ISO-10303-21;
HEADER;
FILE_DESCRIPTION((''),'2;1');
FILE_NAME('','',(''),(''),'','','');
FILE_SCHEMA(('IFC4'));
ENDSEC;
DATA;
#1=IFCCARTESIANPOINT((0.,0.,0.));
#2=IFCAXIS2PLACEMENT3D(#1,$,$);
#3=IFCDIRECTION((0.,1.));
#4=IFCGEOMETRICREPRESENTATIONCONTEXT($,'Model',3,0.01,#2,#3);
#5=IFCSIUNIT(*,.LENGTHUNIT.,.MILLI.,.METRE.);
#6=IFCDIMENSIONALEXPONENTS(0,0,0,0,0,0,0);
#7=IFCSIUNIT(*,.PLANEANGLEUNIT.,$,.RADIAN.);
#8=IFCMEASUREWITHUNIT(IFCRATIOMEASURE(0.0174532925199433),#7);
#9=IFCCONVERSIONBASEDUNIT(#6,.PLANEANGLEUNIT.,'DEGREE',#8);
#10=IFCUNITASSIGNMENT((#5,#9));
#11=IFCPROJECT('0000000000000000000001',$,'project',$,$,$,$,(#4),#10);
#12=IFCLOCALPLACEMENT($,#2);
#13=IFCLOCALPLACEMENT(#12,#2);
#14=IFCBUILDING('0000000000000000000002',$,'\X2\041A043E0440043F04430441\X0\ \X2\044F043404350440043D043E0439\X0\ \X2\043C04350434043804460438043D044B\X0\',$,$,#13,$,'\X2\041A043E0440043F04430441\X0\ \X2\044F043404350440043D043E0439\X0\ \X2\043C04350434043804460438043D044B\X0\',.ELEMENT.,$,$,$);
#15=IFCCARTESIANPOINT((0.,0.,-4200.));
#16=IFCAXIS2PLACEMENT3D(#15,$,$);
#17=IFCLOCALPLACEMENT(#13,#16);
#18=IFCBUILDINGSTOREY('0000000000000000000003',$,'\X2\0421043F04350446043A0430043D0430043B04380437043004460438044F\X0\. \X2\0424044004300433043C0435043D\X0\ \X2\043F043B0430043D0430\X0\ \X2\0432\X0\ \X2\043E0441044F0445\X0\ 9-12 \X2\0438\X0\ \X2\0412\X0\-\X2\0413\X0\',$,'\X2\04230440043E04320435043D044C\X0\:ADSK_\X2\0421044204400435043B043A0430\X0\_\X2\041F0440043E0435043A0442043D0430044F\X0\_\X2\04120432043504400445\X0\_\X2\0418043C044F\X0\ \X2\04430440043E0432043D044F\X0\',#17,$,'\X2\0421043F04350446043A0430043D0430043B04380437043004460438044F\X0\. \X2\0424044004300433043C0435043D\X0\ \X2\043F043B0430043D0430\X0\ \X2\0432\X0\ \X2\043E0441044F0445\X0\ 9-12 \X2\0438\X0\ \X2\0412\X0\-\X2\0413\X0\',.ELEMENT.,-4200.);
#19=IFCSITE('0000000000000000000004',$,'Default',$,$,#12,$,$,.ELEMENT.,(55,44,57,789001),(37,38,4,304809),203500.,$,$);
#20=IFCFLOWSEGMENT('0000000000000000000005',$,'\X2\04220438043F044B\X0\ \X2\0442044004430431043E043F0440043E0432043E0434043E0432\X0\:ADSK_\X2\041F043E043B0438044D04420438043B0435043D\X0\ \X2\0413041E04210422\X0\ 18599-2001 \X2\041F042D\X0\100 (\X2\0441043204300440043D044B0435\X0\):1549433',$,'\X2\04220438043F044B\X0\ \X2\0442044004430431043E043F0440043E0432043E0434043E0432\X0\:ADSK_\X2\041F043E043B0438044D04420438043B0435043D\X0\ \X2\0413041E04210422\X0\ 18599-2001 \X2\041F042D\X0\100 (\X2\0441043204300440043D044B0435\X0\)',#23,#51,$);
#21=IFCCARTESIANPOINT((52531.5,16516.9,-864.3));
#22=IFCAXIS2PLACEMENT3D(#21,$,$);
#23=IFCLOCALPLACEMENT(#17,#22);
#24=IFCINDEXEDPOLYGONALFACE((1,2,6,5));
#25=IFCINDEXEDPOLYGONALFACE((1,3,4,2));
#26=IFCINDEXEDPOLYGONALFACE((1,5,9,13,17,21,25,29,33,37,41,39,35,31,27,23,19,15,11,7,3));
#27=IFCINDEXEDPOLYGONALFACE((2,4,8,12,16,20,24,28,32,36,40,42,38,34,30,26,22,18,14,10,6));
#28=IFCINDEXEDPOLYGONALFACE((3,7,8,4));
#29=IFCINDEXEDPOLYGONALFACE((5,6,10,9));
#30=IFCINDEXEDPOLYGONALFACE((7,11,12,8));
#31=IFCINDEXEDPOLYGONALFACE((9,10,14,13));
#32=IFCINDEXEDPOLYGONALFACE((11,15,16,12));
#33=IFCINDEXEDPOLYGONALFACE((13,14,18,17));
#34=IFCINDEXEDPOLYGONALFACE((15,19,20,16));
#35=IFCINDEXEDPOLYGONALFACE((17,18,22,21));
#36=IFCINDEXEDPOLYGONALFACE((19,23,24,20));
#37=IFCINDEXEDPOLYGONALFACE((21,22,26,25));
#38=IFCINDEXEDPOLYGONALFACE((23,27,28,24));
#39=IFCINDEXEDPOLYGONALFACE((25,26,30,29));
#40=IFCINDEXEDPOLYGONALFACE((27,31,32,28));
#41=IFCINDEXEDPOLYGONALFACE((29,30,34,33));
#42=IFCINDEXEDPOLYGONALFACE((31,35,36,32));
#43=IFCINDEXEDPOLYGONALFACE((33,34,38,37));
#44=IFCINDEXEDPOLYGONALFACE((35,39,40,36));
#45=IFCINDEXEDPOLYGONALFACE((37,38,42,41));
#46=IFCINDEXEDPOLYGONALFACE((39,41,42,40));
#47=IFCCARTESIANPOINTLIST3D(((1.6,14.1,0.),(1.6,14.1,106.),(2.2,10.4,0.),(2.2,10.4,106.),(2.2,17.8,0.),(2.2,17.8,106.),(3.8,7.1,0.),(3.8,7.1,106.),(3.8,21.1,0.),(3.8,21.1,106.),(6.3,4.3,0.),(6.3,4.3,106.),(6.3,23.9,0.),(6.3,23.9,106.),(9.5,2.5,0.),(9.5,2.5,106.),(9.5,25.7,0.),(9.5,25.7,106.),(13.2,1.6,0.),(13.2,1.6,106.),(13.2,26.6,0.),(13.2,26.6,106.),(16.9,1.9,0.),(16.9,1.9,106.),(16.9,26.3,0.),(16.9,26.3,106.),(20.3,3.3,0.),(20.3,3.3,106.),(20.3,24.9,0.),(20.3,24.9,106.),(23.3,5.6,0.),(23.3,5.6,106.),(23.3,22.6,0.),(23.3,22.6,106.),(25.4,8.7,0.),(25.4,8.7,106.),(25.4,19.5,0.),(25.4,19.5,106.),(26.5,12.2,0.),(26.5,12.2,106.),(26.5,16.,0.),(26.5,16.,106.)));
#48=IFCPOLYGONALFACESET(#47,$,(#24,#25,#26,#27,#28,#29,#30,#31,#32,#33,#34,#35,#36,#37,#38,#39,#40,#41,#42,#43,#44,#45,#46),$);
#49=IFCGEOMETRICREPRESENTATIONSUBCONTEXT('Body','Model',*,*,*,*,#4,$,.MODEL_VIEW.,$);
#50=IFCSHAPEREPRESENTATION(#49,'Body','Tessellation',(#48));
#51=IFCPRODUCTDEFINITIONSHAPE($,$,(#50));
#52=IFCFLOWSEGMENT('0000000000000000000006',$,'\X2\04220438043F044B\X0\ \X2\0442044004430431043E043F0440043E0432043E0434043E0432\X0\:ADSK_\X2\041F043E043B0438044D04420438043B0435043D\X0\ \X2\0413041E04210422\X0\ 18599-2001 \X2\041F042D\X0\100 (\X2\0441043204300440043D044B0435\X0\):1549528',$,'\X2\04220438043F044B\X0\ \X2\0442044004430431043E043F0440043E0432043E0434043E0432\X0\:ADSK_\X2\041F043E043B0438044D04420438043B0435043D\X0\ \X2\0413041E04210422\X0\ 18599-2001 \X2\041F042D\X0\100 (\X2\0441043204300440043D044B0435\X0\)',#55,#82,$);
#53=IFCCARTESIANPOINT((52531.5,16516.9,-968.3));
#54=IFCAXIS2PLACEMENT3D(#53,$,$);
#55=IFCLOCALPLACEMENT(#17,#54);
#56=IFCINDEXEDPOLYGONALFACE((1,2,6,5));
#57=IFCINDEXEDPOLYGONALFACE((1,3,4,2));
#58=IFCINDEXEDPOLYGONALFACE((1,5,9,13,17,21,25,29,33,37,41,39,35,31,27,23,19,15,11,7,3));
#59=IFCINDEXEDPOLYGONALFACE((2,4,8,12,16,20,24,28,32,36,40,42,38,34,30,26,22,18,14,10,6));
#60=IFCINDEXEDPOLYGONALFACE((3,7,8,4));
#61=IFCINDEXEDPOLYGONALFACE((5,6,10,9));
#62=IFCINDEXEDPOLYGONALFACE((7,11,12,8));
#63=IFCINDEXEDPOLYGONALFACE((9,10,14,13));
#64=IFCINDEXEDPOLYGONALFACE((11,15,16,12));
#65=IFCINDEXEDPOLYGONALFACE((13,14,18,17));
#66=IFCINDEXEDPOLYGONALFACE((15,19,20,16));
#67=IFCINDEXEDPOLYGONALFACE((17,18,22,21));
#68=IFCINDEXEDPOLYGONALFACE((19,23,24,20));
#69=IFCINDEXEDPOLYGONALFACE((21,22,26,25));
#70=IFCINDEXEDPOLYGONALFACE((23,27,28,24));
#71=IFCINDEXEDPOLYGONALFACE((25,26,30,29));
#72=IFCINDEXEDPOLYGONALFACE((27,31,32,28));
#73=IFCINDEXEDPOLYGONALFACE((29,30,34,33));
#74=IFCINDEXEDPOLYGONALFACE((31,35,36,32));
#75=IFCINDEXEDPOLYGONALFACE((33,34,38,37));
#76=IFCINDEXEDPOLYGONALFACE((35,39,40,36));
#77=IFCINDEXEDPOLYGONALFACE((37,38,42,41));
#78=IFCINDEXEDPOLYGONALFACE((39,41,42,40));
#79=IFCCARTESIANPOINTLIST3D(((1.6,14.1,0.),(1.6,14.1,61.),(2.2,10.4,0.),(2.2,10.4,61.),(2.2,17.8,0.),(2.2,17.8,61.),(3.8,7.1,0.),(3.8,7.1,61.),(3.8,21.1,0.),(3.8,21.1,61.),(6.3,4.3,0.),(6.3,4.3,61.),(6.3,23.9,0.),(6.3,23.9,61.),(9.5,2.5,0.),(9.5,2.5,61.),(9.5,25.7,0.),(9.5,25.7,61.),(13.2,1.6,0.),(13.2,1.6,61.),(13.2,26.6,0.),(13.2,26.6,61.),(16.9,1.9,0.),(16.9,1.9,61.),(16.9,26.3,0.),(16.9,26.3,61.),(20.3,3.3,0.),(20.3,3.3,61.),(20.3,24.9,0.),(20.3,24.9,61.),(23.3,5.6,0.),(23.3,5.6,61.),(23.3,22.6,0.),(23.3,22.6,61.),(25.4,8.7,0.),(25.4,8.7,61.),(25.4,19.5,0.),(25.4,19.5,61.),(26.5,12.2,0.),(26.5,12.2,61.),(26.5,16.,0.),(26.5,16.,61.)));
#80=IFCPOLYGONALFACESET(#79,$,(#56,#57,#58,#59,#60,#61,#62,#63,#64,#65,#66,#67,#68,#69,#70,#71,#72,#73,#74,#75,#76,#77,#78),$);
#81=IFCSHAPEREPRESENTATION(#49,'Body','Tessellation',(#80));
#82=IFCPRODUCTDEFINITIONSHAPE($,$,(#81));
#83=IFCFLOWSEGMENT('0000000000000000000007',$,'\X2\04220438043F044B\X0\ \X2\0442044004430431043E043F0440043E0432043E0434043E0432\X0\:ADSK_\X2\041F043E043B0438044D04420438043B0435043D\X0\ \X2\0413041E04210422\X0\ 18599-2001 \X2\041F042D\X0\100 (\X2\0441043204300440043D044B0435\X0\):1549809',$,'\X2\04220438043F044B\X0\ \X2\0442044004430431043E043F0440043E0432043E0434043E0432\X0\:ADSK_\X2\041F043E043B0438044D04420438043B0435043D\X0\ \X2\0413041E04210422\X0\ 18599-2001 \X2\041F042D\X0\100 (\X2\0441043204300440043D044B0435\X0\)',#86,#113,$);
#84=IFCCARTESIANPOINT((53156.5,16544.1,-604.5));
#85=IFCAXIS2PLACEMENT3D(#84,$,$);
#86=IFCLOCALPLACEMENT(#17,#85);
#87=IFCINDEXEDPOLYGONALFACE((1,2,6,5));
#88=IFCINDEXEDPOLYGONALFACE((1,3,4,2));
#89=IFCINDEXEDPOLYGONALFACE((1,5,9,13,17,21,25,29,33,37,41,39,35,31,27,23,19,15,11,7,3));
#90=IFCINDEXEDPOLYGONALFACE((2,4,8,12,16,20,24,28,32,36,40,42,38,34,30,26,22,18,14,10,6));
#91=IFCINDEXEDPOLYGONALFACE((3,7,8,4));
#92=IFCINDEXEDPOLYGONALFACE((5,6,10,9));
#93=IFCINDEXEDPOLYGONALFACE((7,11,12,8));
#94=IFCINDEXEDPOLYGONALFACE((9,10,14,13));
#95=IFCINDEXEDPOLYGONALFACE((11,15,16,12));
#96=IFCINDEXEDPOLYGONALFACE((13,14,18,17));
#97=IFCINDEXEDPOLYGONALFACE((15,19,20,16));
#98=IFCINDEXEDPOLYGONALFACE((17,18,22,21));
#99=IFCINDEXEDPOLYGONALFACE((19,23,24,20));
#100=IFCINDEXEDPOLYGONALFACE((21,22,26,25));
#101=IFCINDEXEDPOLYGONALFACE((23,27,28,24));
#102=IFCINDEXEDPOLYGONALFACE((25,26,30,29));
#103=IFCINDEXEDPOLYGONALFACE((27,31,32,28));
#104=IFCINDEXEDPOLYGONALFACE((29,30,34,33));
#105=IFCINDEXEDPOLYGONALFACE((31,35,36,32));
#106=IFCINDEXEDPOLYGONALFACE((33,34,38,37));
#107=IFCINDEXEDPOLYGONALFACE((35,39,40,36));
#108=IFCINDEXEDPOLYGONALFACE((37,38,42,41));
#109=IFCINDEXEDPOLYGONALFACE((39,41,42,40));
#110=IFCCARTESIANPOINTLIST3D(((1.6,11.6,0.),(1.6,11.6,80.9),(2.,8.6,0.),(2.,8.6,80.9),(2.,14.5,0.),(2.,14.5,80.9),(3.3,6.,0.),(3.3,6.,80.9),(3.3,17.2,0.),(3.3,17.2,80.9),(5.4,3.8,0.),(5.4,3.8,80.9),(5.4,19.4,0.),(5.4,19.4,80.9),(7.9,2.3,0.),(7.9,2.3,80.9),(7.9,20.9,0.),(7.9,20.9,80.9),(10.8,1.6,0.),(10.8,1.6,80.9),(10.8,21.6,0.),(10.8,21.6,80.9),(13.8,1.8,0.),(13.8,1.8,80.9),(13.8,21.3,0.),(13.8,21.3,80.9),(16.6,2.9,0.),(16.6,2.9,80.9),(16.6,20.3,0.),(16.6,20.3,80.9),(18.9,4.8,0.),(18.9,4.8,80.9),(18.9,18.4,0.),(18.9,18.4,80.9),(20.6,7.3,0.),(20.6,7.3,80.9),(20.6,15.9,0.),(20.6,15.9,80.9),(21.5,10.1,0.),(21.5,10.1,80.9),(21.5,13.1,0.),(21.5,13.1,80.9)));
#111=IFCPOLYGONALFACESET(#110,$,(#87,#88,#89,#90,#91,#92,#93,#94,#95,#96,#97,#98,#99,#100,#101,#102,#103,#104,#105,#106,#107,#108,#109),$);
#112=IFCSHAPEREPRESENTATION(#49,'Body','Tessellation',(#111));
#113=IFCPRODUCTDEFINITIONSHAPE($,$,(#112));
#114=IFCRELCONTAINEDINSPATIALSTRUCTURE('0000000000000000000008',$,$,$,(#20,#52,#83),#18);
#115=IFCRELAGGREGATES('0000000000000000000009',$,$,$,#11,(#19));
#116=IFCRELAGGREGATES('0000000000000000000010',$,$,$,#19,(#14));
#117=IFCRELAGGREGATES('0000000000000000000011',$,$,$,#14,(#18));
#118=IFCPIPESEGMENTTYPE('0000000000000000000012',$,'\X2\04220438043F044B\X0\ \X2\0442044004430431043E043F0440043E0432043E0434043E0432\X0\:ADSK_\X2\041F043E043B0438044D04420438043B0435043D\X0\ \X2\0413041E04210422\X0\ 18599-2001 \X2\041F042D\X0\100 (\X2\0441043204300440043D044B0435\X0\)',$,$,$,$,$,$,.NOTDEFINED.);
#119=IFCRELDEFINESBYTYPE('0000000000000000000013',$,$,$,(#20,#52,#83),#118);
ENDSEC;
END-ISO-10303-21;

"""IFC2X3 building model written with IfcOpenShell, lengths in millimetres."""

from ifc_helpers import new_model, entity, si_unit, converted_unit, direction, frame, frame_2d, origin, origin_2d_with_axis, place, context, subcontext, project, spatial, circle, extrude, type_object, element, save


model = new_model("IFC2X3")

# Units and contexts
model_context = context("Model", 3, precision=0.01, world=origin(), true_north=direction((0.0, 1.0)))
body_context = subcontext(model_context, "Body", "Model", "MODEL_VIEW")
ifc_project = project(units=[si_unit("LENGTHUNIT", "METRE", prefix="MILLI"), converted_unit("PLANEANGLEUNIT", "DEGREE", entity("IfcRatioMeasure", 0.0174532925199433), si_unit("PLANEANGLEUNIT", "RADIAN"), dimensions=[0, 0, 0, 0, 0, 0, 0])], contexts=[model_context])

# Site, building, storey
site_placement = place(None, frame((0.0, 0.0, 0.0)))
site = spatial("IfcSite", under=ifc_project, at=site_placement, Name="Default", CompositionType="ELEMENT", RefLatitude=(55, 44, 57, 789001), RefLongitude=(37, 38, 4, 304809), RefElevation=203500.0)
building_placement = place(site_placement, origin())
building = spatial("IfcBuilding", under=site, at=building_placement, Name="Корпус ядерной медицины", LongName="Корпус ядерной медицины", CompositionType="ELEMENT")
storey_placement = place(building_placement, frame((0.0, 0.0, -4200.0)))
storey = spatial("IfcBuildingStorey", under=building, at=storey_placement, Name="Спецканализация. Фрагмен плана в осях 9-12 и В-Г", ObjectType="Уровень:ADSK_Стрелка_Проектная_Вверх_Имя уровня", LongName="Спецканализация. Фрагмен плана в осях 9-12 и В-Г", CompositionType="ELEMENT", Elevation=-4200.0)

# Flow segments
pipe_segment_type = type_object("IfcPipeSegmentType", Name="Типы трубопроводов:ADSK_Полиэтилен ГОСТ 18599-2001 ПЭ100 (сварные)", PredefinedType="NOTDEFINED")
flow_segment_1_placement = place(storey_placement, frame((52531.5, 16516.9, -864.3)))
element("IfcFlowSegment", 1, at=flow_segment_1_placement, inside=storey, type_object=pipe_segment_type, Name="Типы трубопроводов:ADSK_Полиэтилен ГОСТ 18599-2001 ПЭ100 (сварные):1549433", ObjectType="Типы трубопроводов:ADSK_Полиэтилен ГОСТ 18599-2001 ПЭ100 (сварные)", context=body_context, shape_type="SweptSolid", body=[
    extrude(circle(Radius=12.5, at=frame_2d((0.0, 0.0), x_axis=(1.0, 0.0))), frame((14.1, 14.1, 0.0), z_axis=(0.0, 0.0, 1.0), x_axis=(-1.0, 0.0, 0.0)), (0.0, 0.0, 1.0), 106.0),
])
flow_segment_2_placement = place(storey_placement, frame((52531.5, 16516.9, -968.3)))
element("IfcFlowSegment", 2, at=flow_segment_2_placement, inside=storey, type_object=pipe_segment_type, Name="Типы трубопроводов:ADSK_Полиэтилен ГОСТ 18599-2001 ПЭ100 (сварные):1549528", ObjectType="Типы трубопроводов:ADSK_Полиэтилен ГОСТ 18599-2001 ПЭ100 (сварные)", context=body_context, shape_type="SweptSolid", body=[
    extrude(circle(Radius=12.5, at=origin_2d_with_axis()), frame((14.1, 14.1, 0.0), z_axis=(0.0, 0.0, 1.0), x_axis=(-1.0, 0.0, 0.0)), (0.0, 0.0, 1.0), 61.0),
])
flow_segment_3_placement = place(storey_placement, frame((53156.5, 16544.1, -604.5)))
element("IfcFlowSegment", 3, at=flow_segment_3_placement, inside=storey, type_object=pipe_segment_type, Name="Типы трубопроводов:ADSK_Полиэтилен ГОСТ 18599-2001 ПЭ100 (сварные):1549809", ObjectType="Типы трубопроводов:ADSK_Полиэтилен ГОСТ 18599-2001 ПЭ100 (сварные)", context=body_context, shape_type="SweptSolid", body=[
    extrude(circle(Radius=10.0, at=origin_2d_with_axis()), frame((11.6, 11.6, 0.0), z_axis=(0.0, 0.0, 1.0), x_axis=(-1.0, 0.0, 0.0)), (0.0, 0.0, 1.0), 80.9),
])

save(model, "model.ifc")
